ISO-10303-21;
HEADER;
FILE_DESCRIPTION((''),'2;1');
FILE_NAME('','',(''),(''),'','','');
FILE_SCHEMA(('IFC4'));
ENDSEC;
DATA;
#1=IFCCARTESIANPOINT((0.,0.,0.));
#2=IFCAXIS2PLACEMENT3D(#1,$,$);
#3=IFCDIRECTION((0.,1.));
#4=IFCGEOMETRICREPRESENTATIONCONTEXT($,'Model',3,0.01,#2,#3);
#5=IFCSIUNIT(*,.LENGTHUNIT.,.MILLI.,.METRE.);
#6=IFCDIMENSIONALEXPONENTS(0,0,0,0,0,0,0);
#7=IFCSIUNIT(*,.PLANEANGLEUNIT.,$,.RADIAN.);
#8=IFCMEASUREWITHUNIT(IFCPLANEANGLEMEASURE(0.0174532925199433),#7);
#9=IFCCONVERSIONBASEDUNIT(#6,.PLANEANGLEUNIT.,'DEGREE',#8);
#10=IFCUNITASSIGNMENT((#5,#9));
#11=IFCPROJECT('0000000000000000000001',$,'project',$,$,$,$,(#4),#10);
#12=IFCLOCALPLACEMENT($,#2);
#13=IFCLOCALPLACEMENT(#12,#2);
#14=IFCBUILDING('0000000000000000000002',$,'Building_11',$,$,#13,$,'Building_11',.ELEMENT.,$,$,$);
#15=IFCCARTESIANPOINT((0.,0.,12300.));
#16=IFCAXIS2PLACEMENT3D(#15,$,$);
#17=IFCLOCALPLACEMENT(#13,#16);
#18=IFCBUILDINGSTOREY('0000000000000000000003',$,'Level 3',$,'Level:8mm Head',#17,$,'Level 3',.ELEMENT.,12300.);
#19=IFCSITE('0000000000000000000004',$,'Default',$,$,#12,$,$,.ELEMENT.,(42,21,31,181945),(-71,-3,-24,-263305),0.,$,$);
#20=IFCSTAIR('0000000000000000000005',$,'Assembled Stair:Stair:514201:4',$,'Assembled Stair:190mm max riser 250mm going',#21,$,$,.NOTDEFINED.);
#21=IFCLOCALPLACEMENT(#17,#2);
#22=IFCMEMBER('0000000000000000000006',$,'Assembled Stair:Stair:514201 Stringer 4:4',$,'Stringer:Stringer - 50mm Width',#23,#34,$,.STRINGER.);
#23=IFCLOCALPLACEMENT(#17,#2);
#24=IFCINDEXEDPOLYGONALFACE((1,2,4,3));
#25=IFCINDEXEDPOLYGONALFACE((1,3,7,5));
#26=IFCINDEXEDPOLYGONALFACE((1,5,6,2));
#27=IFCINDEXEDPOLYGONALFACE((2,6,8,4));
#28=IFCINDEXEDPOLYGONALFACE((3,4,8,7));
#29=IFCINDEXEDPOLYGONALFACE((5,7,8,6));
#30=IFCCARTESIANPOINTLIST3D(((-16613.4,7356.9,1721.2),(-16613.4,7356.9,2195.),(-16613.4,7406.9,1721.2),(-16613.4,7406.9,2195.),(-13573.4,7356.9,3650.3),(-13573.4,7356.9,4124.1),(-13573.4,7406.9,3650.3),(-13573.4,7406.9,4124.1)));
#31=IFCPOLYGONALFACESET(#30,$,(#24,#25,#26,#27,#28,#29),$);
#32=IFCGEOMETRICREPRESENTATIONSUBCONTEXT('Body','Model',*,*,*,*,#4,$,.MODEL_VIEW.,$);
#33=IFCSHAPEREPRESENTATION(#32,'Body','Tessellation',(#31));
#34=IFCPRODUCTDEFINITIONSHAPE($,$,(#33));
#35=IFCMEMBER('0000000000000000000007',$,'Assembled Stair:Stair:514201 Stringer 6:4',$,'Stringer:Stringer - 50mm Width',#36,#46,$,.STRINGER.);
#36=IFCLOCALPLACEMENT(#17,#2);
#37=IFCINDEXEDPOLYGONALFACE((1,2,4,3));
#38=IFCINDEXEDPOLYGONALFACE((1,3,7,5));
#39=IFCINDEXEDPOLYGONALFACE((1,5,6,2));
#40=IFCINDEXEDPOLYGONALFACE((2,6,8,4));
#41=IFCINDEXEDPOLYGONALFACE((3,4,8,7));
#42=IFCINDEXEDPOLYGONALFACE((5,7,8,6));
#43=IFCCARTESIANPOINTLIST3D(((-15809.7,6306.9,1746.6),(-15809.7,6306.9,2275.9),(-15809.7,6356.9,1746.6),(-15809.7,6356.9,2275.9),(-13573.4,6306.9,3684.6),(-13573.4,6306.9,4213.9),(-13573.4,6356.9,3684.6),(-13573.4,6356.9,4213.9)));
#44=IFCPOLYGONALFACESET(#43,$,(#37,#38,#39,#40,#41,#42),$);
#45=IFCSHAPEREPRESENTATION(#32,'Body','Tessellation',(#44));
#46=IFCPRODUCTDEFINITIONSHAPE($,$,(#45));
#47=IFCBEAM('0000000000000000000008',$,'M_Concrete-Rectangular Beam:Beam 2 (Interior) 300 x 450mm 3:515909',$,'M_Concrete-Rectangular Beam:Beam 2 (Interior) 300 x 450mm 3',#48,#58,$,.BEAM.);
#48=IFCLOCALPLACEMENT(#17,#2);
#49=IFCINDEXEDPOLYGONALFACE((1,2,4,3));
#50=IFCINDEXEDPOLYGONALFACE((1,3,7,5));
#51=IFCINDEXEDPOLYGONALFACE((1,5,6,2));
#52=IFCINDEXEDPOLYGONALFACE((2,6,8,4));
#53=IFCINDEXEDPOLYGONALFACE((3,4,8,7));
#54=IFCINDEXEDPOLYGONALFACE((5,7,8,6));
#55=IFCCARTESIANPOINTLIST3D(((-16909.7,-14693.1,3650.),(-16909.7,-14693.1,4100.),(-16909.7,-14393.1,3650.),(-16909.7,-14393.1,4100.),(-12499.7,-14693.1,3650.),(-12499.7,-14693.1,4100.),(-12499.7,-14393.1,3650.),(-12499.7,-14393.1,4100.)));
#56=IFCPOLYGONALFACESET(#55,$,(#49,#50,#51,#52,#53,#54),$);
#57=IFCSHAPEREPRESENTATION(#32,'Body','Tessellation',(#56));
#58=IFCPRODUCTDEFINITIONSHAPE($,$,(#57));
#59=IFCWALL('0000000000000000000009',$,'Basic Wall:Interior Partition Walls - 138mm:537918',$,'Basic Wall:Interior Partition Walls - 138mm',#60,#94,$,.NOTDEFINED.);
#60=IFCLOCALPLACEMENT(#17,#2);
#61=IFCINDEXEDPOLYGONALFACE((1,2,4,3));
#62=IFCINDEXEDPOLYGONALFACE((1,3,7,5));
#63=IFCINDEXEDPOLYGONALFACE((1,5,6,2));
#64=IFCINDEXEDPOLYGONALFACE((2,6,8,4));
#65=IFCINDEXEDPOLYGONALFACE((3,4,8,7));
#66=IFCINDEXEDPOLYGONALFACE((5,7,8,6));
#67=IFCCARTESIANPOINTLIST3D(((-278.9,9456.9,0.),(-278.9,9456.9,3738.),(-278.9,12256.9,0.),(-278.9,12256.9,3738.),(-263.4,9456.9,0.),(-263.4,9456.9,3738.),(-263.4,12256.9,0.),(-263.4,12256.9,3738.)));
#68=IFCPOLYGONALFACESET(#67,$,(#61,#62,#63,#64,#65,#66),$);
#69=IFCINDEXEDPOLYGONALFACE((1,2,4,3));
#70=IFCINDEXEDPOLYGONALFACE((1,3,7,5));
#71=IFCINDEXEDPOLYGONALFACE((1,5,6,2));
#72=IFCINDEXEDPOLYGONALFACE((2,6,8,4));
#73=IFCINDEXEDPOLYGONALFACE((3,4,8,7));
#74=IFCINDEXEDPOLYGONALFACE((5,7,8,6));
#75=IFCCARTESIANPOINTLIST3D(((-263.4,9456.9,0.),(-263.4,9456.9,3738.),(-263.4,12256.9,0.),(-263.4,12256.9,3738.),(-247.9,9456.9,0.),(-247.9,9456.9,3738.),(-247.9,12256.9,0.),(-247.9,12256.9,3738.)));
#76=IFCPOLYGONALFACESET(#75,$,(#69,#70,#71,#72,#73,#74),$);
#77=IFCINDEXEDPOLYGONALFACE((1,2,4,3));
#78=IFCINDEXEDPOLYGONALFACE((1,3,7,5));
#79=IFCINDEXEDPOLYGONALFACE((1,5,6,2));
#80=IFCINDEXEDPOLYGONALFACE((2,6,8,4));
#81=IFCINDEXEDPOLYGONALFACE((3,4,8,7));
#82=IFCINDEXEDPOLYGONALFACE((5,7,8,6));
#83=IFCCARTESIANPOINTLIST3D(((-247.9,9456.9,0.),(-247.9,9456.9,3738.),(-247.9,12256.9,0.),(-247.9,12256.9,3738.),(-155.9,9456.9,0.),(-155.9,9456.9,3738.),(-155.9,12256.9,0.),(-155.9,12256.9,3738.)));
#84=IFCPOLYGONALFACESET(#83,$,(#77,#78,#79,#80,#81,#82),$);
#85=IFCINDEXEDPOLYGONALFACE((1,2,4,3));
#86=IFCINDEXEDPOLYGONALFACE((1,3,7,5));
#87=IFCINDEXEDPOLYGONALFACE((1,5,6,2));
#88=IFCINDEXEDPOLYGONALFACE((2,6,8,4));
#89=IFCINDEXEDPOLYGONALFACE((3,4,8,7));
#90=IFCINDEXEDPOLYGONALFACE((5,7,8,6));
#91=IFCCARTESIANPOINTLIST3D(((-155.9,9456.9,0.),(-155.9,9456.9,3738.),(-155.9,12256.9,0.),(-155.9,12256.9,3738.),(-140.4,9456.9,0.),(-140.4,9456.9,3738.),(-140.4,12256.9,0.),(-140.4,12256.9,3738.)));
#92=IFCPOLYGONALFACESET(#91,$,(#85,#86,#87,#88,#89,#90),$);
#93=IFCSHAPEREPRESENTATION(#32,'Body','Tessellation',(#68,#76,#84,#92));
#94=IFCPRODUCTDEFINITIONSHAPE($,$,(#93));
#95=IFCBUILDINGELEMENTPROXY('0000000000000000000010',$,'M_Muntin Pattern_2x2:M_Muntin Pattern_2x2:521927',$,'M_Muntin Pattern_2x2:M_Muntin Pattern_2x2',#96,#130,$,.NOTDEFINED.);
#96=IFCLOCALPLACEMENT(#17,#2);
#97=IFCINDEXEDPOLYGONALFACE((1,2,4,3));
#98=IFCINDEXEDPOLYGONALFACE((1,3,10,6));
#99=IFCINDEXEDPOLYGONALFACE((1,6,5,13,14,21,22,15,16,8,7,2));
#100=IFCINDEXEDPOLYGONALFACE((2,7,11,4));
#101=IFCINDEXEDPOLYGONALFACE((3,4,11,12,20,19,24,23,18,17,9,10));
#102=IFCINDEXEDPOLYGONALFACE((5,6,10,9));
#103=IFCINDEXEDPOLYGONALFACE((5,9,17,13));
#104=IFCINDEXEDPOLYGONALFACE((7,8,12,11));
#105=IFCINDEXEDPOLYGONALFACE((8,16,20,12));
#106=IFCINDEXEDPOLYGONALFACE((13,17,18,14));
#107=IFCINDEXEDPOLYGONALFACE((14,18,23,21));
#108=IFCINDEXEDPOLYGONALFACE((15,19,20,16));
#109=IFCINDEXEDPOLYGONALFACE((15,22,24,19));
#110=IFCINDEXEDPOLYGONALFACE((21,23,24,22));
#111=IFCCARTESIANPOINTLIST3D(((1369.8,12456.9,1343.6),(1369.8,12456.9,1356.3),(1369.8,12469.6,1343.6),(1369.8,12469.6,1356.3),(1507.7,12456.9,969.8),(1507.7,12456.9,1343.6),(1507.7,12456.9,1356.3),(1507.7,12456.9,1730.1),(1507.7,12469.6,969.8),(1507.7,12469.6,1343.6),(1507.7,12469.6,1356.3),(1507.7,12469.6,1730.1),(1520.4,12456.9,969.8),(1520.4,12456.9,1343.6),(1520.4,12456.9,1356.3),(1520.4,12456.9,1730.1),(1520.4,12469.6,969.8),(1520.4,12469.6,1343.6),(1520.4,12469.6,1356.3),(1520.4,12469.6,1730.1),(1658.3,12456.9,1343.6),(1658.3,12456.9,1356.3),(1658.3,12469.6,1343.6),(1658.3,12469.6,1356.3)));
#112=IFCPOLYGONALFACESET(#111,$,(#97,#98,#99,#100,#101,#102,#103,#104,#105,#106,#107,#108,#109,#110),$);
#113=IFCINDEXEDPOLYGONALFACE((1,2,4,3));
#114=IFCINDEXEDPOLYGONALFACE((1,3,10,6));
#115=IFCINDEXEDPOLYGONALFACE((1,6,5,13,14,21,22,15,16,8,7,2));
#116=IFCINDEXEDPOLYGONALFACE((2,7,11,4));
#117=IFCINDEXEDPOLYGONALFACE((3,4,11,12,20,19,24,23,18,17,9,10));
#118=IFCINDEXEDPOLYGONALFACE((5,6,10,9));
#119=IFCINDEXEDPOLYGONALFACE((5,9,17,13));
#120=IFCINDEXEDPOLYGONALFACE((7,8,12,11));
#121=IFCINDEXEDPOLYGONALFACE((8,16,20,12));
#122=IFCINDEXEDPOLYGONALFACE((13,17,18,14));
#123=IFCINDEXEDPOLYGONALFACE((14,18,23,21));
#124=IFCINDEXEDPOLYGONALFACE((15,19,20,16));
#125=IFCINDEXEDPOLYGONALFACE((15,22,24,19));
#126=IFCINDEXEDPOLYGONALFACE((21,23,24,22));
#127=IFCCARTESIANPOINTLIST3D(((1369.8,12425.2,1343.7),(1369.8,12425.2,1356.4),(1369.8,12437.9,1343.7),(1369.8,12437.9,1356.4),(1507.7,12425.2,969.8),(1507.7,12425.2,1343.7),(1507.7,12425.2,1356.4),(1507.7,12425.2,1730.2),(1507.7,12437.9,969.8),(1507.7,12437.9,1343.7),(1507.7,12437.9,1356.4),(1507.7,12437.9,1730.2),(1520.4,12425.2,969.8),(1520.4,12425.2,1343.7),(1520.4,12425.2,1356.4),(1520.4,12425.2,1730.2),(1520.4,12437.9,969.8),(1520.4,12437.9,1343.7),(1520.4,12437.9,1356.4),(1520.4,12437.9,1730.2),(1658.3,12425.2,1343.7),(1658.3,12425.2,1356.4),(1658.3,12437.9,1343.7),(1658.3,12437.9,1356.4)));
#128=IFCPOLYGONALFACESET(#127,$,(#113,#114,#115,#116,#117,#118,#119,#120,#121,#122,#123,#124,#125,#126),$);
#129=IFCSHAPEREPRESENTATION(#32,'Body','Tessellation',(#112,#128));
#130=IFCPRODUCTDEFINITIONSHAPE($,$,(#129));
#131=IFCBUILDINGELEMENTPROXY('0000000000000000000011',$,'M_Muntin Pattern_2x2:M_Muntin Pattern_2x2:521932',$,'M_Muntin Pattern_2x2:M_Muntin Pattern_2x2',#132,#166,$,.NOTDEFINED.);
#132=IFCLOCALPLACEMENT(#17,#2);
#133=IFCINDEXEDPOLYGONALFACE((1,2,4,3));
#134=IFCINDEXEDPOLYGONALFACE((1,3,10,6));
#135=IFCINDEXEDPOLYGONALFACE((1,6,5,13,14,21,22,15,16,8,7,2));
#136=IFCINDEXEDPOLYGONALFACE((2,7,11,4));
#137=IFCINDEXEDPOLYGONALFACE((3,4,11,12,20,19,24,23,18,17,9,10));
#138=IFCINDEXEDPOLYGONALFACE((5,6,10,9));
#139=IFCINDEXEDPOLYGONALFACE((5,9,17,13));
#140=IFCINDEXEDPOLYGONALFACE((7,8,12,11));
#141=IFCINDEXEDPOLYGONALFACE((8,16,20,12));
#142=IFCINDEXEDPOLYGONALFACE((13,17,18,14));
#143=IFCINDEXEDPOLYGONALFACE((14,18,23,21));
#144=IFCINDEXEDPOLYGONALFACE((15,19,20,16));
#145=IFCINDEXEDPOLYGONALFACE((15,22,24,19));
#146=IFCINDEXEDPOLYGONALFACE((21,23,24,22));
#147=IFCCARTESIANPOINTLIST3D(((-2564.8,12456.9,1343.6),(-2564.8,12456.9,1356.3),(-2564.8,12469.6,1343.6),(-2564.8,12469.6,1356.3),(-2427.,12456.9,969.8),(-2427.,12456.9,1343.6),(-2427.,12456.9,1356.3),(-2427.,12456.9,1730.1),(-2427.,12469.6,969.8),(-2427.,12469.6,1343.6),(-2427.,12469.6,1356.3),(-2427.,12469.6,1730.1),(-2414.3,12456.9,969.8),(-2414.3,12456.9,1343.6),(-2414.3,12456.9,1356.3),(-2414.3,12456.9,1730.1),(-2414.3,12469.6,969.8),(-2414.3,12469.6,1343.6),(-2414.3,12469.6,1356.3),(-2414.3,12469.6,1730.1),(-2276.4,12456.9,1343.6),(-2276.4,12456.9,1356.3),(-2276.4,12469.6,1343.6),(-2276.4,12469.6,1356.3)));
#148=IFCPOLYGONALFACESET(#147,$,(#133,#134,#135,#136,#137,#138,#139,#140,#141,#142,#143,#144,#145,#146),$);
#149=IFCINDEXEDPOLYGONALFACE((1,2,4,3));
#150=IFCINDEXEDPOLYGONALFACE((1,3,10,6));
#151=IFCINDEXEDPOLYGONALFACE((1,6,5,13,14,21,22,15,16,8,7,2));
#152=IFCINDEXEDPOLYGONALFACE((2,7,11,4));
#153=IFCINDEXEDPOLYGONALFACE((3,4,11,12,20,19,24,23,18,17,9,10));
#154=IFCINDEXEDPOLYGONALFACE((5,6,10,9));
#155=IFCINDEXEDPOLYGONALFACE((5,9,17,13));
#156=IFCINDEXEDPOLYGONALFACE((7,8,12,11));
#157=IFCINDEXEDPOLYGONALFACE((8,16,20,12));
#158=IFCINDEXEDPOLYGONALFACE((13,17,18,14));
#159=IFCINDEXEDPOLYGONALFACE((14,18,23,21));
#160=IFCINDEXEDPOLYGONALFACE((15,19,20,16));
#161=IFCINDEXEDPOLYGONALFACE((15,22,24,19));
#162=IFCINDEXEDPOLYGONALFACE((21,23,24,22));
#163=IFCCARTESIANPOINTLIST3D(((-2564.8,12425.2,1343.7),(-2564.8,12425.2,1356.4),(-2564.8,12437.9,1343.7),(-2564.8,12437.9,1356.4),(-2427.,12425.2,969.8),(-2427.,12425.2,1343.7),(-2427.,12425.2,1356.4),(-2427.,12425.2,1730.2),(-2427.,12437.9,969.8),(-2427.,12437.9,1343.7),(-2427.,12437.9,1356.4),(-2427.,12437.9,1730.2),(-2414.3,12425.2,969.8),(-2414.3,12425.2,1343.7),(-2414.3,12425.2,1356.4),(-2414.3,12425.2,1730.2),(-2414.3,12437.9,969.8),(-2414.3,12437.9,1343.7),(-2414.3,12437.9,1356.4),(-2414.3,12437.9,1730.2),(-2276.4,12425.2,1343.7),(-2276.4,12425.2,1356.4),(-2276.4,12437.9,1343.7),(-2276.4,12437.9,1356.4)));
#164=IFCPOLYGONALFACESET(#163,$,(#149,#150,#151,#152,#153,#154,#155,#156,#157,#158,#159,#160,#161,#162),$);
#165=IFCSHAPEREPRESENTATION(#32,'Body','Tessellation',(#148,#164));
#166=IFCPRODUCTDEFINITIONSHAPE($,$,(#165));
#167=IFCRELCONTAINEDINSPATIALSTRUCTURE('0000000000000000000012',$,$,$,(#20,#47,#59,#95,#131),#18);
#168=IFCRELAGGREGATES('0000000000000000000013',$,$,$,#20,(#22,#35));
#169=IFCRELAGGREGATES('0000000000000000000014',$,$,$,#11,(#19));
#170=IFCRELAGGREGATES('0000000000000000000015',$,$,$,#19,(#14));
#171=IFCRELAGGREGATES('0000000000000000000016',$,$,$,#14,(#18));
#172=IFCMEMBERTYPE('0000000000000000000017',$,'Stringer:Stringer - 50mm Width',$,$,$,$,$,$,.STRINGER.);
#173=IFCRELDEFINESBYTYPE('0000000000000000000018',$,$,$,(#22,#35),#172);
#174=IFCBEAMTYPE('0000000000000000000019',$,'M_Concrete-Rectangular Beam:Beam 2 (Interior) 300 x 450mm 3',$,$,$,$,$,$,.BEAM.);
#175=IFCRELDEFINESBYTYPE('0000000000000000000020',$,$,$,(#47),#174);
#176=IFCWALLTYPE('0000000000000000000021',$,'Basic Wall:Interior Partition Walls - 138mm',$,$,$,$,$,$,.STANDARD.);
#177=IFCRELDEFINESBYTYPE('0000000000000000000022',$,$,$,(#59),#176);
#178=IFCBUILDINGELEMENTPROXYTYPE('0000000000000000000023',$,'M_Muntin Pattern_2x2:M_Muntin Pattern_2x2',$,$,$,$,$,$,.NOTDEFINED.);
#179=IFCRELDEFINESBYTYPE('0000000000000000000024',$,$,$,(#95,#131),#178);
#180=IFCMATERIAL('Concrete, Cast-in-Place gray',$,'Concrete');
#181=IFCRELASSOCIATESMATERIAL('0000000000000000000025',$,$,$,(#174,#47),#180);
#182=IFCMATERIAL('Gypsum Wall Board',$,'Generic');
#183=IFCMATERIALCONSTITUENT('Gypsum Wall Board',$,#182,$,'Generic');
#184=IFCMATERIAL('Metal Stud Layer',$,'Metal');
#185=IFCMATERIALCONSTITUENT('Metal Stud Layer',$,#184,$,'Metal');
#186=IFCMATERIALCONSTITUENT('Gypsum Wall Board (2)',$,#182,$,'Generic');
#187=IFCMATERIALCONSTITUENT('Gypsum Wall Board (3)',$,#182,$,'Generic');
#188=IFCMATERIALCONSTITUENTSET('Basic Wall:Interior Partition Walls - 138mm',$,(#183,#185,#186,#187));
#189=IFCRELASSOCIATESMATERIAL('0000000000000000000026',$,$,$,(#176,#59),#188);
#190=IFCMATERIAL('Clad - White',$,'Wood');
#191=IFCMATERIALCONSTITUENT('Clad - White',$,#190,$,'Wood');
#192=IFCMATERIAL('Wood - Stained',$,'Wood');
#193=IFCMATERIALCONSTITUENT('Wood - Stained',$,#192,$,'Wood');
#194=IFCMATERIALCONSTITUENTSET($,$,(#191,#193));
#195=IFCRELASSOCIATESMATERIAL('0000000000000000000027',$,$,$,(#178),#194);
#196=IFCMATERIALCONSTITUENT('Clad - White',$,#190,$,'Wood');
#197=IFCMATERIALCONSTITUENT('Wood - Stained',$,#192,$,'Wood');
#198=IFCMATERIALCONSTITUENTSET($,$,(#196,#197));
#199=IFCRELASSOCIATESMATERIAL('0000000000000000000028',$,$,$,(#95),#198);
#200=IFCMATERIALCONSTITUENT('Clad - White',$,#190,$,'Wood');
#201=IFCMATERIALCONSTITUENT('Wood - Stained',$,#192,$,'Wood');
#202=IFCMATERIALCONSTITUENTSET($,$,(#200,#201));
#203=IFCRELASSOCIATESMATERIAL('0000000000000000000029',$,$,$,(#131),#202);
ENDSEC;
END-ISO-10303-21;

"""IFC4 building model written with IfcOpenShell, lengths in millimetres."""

from ifc_helpers import new_model, entity, si_unit, converted_unit, direction, frame, origin, place, context, subcontext, project, spatial, indexed_curve, outline, extrude, source, transform, mapped, material, constituent, constituent_set, type_object, type_shapes, element, aggregate, save


model = new_model("IFC4")

# Units and contexts
model_context = context("Model", 3, precision=0.01, world=origin(), true_north=direction((0.0, 1.0)))
body_context = subcontext(model_context, "Body", "Model", "MODEL_VIEW")
ifc_project = project(units=[si_unit("LENGTHUNIT", "METRE", prefix="MILLI"), converted_unit("PLANEANGLEUNIT", "DEGREE", entity("IfcPlaneAngleMeasure", 0.0174532925199433), si_unit("PLANEANGLEUNIT", "RADIAN"), dimensions=[0, 0, 0, 0, 0, 0, 0])], contexts=[model_context])

# Site, building, storey
site_placement = place(None, origin())
site = spatial("IfcSite", under=ifc_project, at=site_placement, Name="Default", CompositionType="ELEMENT", RefLatitude=(42, 21, 31, 181945), RefLongitude=(-71, -3, -24, -263305), RefElevation=0.0)
building_placement = place(site_placement, origin())
building = spatial("IfcBuilding", under=site, at=building_placement, Name="Building_11", LongName="Building_11", CompositionType="ELEMENT")
storey_placement = place(building_placement, frame((0.0, 0.0, 12300.0)))
storey = spatial("IfcBuildingStorey", under=building, at=storey_placement, Name="Level 3", ObjectType="Level:8mm Head", LongName="Level 3", CompositionType="ELEMENT", Elevation=12300.0)

# Stair, members
stair_placement = place(storey_placement, origin())
stair = element("IfcStair", 1, at=stair_placement, inside=storey, Name="Assembled Stair:Stair:514201:4", ObjectType="Assembled Stair:190mm max riser 250mm going", PredefinedType="NOTDEFINED")
member_type = type_object("IfcMemberType", Name="Stringer:Stringer - 50mm Width", PredefinedType="STRINGER")
member_1_placement = place(stair_placement, origin())
member_1 = element("IfcMember", 2, at=member_1_placement, type_object=member_type, Name="Assembled Stair:Stair:514201 Stringer 4:4", ObjectType="Stringer:Stringer - 50mm Width", PredefinedType="STRINGER", context=body_context, shape_type="SweptSolid", body=[
    extrude(outline(indexed_curve([(-1673.3, -200.0), (1927.1, -200.0), (1673.3, 200.0), (-1927.1, 200.0), (-1673.3, -200.0)], self_intersect=False)), frame((-15093.4, 7356.9, 2922.7), z_axis=(0.0, 1.0, 0.0), x_axis=(0.844349, 0.0, 0.535794)), (0.0, 0.0, 1.0), 50.0),
])
member_2_placement = place(stair_placement, origin())
member_2 = element("IfcMember", 3, at=member_2_placement, type_object=member_type, Name="Assembled Stair:Stair:514201 Stringer 6:4", ObjectType="Stringer:Stringer - 50mm Width", PredefinedType="STRINGER", context=body_context, shape_type="SweptSolid", body=[
    extrude(outline(indexed_curve([(-1306.3, -200.0), (1653.0, -200.0), (1306.3, 200.0), (-1653.0, 200.0), (-1306.3, -200.0)], self_intersect=False)), frame((-14691.5, 6306.9, 2980.2), z_axis=(0.0, 1.0, 0.0), x_axis=(0.755705, 0.0, 0.654912)), (0.0, 0.0, 1.0), 50.0),
])

# Beam
ifc_material_1 = material(Name="Concrete, Cast-in-Place gray", Category="Concrete")
beam_type = type_object("IfcBeamType", Name="M_Concrete-Rectangular Beam:Beam 2 (Interior) 300 x 450mm 3", PredefinedType="BEAM", material=ifc_material_1)
shared_shape_1 = source(origin(), body_context, "Body", "SweptSolid", [
    extrude(outline(indexed_curve([(-225.0, -150.0), (225.0, -150.0), (225.0, 150.0), (-225.0, 150.0), (-225.0, -150.0)], self_intersect=False)), frame((-16909.7, -14543.1, 16175.0), z_axis=(1.0, 0.0, 0.0), x_axis=(0.0, 0.0, -1.0)), (0.0, 0.0, 1.0), 4410.0),
])
type_shapes(beam_type, [shared_shape_1])
beam_placement = place(storey_placement, frame((0.0, 0.0, -12300.0)))
element("IfcBeam", 4, at=beam_placement, inside=storey, type_object=beam_type, material=ifc_material_1, Name="M_Concrete-Rectangular Beam:Beam 2 (Interior) 300 x 450mm 3:515909", ObjectType="M_Concrete-Rectangular Beam:Beam 2 (Interior) 300 x 450mm 3", PredefinedType="BEAM", context=body_context, shape_type="MappedRepresentation", body=[
    mapped(shared_shape_1, transform((0.0, 0.0, 0.0), scale=1.0)),
])

# Wall
ifc_material_2 = material(Name="Gypsum Wall Board", Category="Generic")
ifc_constituent_1 = constituent(ifc_material_2, Name="Gypsum Wall Board", Category="Generic")
ifc_material_3 = material(Name="Metal Stud Layer", Category="Metal")
ifc_constituent_2 = constituent(ifc_material_3, Name="Metal Stud Layer", Category="Metal")
ifc_constituent_3 = constituent(ifc_material_2, Name="Gypsum Wall Board (2)", Category="Generic")
ifc_constituent_4 = constituent(ifc_material_2, Name="Gypsum Wall Board (3)", Category="Generic")
ifc_constituent_set_1 = constituent_set(constituents=[ifc_constituent_1, ifc_constituent_2, ifc_constituent_3, ifc_constituent_4], Name="Basic Wall:Interior Partition Walls - 138mm")
wall_type = type_object("IfcWallType", Name="Basic Wall:Interior Partition Walls - 138mm", PredefinedType="STANDARD", material=ifc_constituent_set_1)
wall_placement = place(storey_placement, frame((-209.7, 12256.9, 0.0), z_axis=(0.0, 0.0, 1.0), x_axis=(0.0, -1.0, 0.0)))
element("IfcWall", 5, at=wall_placement, inside=storey, type_object=wall_type, material=ifc_constituent_set_1, Name="Basic Wall:Interior Partition Walls - 138mm:537918", ObjectType="Basic Wall:Interior Partition Walls - 138mm", PredefinedType="NOTDEFINED", context=body_context, shape_type="SweptSolid", body=[
    extrude(outline(indexed_curve([(-1869.0, -1400.0), (1869.0, -1400.0), (1869.0, 1400.0), (-1869.0, 1400.0), (-1869.0, -1400.0)], self_intersect=False)), frame((1400.0, -69.2, 1869.0), z_axis=(0.0, 1.0, 0.0), x_axis=(0.0, 0.0, 1.0)), (0.0, 0.0, 1.0), 15.5),
    extrude(outline(indexed_curve([(-1869.0, -1400.0), (1869.0, -1400.0), (1869.0, 1400.0), (-1869.0, 1400.0), (-1869.0, -1400.0)], self_intersect=False)), frame((1400.0, -53.8, 1869.0), z_axis=(0.0, 1.0, 0.0), x_axis=(0.0, 0.0, 1.0)), (0.0, 0.0, 1.0), 15.5),
    extrude(outline(indexed_curve([(-1869.0, -1400.0), (1869.0, -1400.0), (1869.0, 1400.0), (-1869.0, 1400.0), (-1869.0, -1400.0)], self_intersect=False)), frame((1400.0, -38.2, 1869.0), z_axis=(0.0, 1.0, 0.0), x_axis=(0.0, 0.0, 1.0)), (0.0, 0.0, 1.0), 92.0),
    extrude(outline(indexed_curve([(-1869.0, -1400.0), (1869.0, -1400.0), (1869.0, 1400.0), (-1869.0, 1400.0), (-1869.0, -1400.0)], self_intersect=False)), frame((1400.0, 53.7, 1869.0), z_axis=(0.0, 1.0, 0.0), x_axis=(0.0, 0.0, 1.0)), (0.0, 0.0, 1.0), 15.5),
])

aggregate(stair, [member_1, member_2])

# Building element proxies
ifc_material_4 = material(Name="Clad - White", Category="Wood")
ifc_constituent_5 = constituent(ifc_material_4, Name="Clad - White", Category="Wood")
ifc_material_5 = material(Name="Wood - Stained", Category="Wood")
ifc_constituent_6 = constituent(ifc_material_5, Name="Wood - Stained", Category="Wood")
ifc_constituent_set_2 = constituent_set(constituents=[ifc_constituent_5, ifc_constituent_6])
ifc_constituent_7 = constituent(ifc_material_4, Name="Clad - White", Category="Wood")
ifc_constituent_8 = constituent(ifc_material_5, Name="Wood - Stained", Category="Wood")
ifc_constituent_set_3 = constituent_set(constituents=[ifc_constituent_7, ifc_constituent_8])
building_element_proxy_type_1 = type_object("IfcBuildingElementProxyType", Name="M_Muntin Pattern_2x2:M_Muntin Pattern_2x2", PredefinedType="NOTDEFINED", material=ifc_constituent_set_3)
shared_shape_2 = source(origin(), body_context, "Body", "SweptSolid", [
    extrude(outline(indexed_curve([(6.4, -6.4), (380.1, -6.4), (380.1, 6.3), (6.4, 6.3), (6.4, 144.2), (-6.3, 144.2), (-6.3, 6.3), (-380.2, 6.3), (-380.2, -6.4), (-6.3, -6.4), (-6.3, -144.2), (6.4, -144.2), (6.4, -6.4)], self_intersect=False)), frame((0.0, 9.5, 380.1), z_axis=(0.0, 1.0, 0.0), x_axis=(0.0, 0.0, 1.0)), (0.0, 0.0, 1.0), 12.7),
    extrude(outline(indexed_curve([(6.4, -6.4), (380.2, -6.4), (380.2, 6.3), (6.4, 6.3), (6.4, 144.2), (-6.3, 144.2), (-6.3, 6.3), (-380.2, 6.3), (-380.2, -6.4), (-6.3, -6.4), (-6.3, -144.2), (6.4, -144.2), (6.4, -6.4)], self_intersect=False)), frame((0.0, -22.2, 380.2), z_axis=(0.0, 1.0, 0.0), x_axis=(0.0, 0.0, 1.0)), (0.0, 0.0, 1.0), 12.7),
])
type_shapes(building_element_proxy_type_1, [shared_shape_2])
proxy_1_placement = place(storey_placement, frame((1514.0, 12447.4, 969.8)))
element("IfcBuildingElementProxy", 6, at=proxy_1_placement, inside=storey, type_object=building_element_proxy_type_1, material=ifc_constituent_set_2, Name="M_Muntin Pattern_2x2:M_Muntin Pattern_2x2:521927", ObjectType="M_Muntin Pattern_2x2:M_Muntin Pattern_2x2", PredefinedType="NOTDEFINED", context=body_context, shape_type="MappedRepresentation", body=[
    mapped(shared_shape_2, transform((0.0, 0.0, 0.0), scale=1.0)),
])
ifc_constituent_9 = constituent(ifc_material_4, Name="Clad - White", Category="Wood")
ifc_constituent_10 = constituent(ifc_material_5, Name="Wood - Stained", Category="Wood")
ifc_constituent_set_4 = constituent_set(constituents=[ifc_constituent_9, ifc_constituent_10])
proxy_2_placement = place(storey_placement, frame((-2420.6, 12447.4, 969.8)))
element("IfcBuildingElementProxy", 7, at=proxy_2_placement, inside=storey, type_object=building_element_proxy_type_1, material=ifc_constituent_set_4, Name="M_Muntin Pattern_2x2:M_Muntin Pattern_2x2:521932", ObjectType="M_Muntin Pattern_2x2:M_Muntin Pattern_2x2", PredefinedType="NOTDEFINED", context=body_context, shape_type="MappedRepresentation", body=[
    mapped(shared_shape_2, transform((0.0, 0.0, 0.0), scale=1.0)),
])

save(model, "model.ifc")
